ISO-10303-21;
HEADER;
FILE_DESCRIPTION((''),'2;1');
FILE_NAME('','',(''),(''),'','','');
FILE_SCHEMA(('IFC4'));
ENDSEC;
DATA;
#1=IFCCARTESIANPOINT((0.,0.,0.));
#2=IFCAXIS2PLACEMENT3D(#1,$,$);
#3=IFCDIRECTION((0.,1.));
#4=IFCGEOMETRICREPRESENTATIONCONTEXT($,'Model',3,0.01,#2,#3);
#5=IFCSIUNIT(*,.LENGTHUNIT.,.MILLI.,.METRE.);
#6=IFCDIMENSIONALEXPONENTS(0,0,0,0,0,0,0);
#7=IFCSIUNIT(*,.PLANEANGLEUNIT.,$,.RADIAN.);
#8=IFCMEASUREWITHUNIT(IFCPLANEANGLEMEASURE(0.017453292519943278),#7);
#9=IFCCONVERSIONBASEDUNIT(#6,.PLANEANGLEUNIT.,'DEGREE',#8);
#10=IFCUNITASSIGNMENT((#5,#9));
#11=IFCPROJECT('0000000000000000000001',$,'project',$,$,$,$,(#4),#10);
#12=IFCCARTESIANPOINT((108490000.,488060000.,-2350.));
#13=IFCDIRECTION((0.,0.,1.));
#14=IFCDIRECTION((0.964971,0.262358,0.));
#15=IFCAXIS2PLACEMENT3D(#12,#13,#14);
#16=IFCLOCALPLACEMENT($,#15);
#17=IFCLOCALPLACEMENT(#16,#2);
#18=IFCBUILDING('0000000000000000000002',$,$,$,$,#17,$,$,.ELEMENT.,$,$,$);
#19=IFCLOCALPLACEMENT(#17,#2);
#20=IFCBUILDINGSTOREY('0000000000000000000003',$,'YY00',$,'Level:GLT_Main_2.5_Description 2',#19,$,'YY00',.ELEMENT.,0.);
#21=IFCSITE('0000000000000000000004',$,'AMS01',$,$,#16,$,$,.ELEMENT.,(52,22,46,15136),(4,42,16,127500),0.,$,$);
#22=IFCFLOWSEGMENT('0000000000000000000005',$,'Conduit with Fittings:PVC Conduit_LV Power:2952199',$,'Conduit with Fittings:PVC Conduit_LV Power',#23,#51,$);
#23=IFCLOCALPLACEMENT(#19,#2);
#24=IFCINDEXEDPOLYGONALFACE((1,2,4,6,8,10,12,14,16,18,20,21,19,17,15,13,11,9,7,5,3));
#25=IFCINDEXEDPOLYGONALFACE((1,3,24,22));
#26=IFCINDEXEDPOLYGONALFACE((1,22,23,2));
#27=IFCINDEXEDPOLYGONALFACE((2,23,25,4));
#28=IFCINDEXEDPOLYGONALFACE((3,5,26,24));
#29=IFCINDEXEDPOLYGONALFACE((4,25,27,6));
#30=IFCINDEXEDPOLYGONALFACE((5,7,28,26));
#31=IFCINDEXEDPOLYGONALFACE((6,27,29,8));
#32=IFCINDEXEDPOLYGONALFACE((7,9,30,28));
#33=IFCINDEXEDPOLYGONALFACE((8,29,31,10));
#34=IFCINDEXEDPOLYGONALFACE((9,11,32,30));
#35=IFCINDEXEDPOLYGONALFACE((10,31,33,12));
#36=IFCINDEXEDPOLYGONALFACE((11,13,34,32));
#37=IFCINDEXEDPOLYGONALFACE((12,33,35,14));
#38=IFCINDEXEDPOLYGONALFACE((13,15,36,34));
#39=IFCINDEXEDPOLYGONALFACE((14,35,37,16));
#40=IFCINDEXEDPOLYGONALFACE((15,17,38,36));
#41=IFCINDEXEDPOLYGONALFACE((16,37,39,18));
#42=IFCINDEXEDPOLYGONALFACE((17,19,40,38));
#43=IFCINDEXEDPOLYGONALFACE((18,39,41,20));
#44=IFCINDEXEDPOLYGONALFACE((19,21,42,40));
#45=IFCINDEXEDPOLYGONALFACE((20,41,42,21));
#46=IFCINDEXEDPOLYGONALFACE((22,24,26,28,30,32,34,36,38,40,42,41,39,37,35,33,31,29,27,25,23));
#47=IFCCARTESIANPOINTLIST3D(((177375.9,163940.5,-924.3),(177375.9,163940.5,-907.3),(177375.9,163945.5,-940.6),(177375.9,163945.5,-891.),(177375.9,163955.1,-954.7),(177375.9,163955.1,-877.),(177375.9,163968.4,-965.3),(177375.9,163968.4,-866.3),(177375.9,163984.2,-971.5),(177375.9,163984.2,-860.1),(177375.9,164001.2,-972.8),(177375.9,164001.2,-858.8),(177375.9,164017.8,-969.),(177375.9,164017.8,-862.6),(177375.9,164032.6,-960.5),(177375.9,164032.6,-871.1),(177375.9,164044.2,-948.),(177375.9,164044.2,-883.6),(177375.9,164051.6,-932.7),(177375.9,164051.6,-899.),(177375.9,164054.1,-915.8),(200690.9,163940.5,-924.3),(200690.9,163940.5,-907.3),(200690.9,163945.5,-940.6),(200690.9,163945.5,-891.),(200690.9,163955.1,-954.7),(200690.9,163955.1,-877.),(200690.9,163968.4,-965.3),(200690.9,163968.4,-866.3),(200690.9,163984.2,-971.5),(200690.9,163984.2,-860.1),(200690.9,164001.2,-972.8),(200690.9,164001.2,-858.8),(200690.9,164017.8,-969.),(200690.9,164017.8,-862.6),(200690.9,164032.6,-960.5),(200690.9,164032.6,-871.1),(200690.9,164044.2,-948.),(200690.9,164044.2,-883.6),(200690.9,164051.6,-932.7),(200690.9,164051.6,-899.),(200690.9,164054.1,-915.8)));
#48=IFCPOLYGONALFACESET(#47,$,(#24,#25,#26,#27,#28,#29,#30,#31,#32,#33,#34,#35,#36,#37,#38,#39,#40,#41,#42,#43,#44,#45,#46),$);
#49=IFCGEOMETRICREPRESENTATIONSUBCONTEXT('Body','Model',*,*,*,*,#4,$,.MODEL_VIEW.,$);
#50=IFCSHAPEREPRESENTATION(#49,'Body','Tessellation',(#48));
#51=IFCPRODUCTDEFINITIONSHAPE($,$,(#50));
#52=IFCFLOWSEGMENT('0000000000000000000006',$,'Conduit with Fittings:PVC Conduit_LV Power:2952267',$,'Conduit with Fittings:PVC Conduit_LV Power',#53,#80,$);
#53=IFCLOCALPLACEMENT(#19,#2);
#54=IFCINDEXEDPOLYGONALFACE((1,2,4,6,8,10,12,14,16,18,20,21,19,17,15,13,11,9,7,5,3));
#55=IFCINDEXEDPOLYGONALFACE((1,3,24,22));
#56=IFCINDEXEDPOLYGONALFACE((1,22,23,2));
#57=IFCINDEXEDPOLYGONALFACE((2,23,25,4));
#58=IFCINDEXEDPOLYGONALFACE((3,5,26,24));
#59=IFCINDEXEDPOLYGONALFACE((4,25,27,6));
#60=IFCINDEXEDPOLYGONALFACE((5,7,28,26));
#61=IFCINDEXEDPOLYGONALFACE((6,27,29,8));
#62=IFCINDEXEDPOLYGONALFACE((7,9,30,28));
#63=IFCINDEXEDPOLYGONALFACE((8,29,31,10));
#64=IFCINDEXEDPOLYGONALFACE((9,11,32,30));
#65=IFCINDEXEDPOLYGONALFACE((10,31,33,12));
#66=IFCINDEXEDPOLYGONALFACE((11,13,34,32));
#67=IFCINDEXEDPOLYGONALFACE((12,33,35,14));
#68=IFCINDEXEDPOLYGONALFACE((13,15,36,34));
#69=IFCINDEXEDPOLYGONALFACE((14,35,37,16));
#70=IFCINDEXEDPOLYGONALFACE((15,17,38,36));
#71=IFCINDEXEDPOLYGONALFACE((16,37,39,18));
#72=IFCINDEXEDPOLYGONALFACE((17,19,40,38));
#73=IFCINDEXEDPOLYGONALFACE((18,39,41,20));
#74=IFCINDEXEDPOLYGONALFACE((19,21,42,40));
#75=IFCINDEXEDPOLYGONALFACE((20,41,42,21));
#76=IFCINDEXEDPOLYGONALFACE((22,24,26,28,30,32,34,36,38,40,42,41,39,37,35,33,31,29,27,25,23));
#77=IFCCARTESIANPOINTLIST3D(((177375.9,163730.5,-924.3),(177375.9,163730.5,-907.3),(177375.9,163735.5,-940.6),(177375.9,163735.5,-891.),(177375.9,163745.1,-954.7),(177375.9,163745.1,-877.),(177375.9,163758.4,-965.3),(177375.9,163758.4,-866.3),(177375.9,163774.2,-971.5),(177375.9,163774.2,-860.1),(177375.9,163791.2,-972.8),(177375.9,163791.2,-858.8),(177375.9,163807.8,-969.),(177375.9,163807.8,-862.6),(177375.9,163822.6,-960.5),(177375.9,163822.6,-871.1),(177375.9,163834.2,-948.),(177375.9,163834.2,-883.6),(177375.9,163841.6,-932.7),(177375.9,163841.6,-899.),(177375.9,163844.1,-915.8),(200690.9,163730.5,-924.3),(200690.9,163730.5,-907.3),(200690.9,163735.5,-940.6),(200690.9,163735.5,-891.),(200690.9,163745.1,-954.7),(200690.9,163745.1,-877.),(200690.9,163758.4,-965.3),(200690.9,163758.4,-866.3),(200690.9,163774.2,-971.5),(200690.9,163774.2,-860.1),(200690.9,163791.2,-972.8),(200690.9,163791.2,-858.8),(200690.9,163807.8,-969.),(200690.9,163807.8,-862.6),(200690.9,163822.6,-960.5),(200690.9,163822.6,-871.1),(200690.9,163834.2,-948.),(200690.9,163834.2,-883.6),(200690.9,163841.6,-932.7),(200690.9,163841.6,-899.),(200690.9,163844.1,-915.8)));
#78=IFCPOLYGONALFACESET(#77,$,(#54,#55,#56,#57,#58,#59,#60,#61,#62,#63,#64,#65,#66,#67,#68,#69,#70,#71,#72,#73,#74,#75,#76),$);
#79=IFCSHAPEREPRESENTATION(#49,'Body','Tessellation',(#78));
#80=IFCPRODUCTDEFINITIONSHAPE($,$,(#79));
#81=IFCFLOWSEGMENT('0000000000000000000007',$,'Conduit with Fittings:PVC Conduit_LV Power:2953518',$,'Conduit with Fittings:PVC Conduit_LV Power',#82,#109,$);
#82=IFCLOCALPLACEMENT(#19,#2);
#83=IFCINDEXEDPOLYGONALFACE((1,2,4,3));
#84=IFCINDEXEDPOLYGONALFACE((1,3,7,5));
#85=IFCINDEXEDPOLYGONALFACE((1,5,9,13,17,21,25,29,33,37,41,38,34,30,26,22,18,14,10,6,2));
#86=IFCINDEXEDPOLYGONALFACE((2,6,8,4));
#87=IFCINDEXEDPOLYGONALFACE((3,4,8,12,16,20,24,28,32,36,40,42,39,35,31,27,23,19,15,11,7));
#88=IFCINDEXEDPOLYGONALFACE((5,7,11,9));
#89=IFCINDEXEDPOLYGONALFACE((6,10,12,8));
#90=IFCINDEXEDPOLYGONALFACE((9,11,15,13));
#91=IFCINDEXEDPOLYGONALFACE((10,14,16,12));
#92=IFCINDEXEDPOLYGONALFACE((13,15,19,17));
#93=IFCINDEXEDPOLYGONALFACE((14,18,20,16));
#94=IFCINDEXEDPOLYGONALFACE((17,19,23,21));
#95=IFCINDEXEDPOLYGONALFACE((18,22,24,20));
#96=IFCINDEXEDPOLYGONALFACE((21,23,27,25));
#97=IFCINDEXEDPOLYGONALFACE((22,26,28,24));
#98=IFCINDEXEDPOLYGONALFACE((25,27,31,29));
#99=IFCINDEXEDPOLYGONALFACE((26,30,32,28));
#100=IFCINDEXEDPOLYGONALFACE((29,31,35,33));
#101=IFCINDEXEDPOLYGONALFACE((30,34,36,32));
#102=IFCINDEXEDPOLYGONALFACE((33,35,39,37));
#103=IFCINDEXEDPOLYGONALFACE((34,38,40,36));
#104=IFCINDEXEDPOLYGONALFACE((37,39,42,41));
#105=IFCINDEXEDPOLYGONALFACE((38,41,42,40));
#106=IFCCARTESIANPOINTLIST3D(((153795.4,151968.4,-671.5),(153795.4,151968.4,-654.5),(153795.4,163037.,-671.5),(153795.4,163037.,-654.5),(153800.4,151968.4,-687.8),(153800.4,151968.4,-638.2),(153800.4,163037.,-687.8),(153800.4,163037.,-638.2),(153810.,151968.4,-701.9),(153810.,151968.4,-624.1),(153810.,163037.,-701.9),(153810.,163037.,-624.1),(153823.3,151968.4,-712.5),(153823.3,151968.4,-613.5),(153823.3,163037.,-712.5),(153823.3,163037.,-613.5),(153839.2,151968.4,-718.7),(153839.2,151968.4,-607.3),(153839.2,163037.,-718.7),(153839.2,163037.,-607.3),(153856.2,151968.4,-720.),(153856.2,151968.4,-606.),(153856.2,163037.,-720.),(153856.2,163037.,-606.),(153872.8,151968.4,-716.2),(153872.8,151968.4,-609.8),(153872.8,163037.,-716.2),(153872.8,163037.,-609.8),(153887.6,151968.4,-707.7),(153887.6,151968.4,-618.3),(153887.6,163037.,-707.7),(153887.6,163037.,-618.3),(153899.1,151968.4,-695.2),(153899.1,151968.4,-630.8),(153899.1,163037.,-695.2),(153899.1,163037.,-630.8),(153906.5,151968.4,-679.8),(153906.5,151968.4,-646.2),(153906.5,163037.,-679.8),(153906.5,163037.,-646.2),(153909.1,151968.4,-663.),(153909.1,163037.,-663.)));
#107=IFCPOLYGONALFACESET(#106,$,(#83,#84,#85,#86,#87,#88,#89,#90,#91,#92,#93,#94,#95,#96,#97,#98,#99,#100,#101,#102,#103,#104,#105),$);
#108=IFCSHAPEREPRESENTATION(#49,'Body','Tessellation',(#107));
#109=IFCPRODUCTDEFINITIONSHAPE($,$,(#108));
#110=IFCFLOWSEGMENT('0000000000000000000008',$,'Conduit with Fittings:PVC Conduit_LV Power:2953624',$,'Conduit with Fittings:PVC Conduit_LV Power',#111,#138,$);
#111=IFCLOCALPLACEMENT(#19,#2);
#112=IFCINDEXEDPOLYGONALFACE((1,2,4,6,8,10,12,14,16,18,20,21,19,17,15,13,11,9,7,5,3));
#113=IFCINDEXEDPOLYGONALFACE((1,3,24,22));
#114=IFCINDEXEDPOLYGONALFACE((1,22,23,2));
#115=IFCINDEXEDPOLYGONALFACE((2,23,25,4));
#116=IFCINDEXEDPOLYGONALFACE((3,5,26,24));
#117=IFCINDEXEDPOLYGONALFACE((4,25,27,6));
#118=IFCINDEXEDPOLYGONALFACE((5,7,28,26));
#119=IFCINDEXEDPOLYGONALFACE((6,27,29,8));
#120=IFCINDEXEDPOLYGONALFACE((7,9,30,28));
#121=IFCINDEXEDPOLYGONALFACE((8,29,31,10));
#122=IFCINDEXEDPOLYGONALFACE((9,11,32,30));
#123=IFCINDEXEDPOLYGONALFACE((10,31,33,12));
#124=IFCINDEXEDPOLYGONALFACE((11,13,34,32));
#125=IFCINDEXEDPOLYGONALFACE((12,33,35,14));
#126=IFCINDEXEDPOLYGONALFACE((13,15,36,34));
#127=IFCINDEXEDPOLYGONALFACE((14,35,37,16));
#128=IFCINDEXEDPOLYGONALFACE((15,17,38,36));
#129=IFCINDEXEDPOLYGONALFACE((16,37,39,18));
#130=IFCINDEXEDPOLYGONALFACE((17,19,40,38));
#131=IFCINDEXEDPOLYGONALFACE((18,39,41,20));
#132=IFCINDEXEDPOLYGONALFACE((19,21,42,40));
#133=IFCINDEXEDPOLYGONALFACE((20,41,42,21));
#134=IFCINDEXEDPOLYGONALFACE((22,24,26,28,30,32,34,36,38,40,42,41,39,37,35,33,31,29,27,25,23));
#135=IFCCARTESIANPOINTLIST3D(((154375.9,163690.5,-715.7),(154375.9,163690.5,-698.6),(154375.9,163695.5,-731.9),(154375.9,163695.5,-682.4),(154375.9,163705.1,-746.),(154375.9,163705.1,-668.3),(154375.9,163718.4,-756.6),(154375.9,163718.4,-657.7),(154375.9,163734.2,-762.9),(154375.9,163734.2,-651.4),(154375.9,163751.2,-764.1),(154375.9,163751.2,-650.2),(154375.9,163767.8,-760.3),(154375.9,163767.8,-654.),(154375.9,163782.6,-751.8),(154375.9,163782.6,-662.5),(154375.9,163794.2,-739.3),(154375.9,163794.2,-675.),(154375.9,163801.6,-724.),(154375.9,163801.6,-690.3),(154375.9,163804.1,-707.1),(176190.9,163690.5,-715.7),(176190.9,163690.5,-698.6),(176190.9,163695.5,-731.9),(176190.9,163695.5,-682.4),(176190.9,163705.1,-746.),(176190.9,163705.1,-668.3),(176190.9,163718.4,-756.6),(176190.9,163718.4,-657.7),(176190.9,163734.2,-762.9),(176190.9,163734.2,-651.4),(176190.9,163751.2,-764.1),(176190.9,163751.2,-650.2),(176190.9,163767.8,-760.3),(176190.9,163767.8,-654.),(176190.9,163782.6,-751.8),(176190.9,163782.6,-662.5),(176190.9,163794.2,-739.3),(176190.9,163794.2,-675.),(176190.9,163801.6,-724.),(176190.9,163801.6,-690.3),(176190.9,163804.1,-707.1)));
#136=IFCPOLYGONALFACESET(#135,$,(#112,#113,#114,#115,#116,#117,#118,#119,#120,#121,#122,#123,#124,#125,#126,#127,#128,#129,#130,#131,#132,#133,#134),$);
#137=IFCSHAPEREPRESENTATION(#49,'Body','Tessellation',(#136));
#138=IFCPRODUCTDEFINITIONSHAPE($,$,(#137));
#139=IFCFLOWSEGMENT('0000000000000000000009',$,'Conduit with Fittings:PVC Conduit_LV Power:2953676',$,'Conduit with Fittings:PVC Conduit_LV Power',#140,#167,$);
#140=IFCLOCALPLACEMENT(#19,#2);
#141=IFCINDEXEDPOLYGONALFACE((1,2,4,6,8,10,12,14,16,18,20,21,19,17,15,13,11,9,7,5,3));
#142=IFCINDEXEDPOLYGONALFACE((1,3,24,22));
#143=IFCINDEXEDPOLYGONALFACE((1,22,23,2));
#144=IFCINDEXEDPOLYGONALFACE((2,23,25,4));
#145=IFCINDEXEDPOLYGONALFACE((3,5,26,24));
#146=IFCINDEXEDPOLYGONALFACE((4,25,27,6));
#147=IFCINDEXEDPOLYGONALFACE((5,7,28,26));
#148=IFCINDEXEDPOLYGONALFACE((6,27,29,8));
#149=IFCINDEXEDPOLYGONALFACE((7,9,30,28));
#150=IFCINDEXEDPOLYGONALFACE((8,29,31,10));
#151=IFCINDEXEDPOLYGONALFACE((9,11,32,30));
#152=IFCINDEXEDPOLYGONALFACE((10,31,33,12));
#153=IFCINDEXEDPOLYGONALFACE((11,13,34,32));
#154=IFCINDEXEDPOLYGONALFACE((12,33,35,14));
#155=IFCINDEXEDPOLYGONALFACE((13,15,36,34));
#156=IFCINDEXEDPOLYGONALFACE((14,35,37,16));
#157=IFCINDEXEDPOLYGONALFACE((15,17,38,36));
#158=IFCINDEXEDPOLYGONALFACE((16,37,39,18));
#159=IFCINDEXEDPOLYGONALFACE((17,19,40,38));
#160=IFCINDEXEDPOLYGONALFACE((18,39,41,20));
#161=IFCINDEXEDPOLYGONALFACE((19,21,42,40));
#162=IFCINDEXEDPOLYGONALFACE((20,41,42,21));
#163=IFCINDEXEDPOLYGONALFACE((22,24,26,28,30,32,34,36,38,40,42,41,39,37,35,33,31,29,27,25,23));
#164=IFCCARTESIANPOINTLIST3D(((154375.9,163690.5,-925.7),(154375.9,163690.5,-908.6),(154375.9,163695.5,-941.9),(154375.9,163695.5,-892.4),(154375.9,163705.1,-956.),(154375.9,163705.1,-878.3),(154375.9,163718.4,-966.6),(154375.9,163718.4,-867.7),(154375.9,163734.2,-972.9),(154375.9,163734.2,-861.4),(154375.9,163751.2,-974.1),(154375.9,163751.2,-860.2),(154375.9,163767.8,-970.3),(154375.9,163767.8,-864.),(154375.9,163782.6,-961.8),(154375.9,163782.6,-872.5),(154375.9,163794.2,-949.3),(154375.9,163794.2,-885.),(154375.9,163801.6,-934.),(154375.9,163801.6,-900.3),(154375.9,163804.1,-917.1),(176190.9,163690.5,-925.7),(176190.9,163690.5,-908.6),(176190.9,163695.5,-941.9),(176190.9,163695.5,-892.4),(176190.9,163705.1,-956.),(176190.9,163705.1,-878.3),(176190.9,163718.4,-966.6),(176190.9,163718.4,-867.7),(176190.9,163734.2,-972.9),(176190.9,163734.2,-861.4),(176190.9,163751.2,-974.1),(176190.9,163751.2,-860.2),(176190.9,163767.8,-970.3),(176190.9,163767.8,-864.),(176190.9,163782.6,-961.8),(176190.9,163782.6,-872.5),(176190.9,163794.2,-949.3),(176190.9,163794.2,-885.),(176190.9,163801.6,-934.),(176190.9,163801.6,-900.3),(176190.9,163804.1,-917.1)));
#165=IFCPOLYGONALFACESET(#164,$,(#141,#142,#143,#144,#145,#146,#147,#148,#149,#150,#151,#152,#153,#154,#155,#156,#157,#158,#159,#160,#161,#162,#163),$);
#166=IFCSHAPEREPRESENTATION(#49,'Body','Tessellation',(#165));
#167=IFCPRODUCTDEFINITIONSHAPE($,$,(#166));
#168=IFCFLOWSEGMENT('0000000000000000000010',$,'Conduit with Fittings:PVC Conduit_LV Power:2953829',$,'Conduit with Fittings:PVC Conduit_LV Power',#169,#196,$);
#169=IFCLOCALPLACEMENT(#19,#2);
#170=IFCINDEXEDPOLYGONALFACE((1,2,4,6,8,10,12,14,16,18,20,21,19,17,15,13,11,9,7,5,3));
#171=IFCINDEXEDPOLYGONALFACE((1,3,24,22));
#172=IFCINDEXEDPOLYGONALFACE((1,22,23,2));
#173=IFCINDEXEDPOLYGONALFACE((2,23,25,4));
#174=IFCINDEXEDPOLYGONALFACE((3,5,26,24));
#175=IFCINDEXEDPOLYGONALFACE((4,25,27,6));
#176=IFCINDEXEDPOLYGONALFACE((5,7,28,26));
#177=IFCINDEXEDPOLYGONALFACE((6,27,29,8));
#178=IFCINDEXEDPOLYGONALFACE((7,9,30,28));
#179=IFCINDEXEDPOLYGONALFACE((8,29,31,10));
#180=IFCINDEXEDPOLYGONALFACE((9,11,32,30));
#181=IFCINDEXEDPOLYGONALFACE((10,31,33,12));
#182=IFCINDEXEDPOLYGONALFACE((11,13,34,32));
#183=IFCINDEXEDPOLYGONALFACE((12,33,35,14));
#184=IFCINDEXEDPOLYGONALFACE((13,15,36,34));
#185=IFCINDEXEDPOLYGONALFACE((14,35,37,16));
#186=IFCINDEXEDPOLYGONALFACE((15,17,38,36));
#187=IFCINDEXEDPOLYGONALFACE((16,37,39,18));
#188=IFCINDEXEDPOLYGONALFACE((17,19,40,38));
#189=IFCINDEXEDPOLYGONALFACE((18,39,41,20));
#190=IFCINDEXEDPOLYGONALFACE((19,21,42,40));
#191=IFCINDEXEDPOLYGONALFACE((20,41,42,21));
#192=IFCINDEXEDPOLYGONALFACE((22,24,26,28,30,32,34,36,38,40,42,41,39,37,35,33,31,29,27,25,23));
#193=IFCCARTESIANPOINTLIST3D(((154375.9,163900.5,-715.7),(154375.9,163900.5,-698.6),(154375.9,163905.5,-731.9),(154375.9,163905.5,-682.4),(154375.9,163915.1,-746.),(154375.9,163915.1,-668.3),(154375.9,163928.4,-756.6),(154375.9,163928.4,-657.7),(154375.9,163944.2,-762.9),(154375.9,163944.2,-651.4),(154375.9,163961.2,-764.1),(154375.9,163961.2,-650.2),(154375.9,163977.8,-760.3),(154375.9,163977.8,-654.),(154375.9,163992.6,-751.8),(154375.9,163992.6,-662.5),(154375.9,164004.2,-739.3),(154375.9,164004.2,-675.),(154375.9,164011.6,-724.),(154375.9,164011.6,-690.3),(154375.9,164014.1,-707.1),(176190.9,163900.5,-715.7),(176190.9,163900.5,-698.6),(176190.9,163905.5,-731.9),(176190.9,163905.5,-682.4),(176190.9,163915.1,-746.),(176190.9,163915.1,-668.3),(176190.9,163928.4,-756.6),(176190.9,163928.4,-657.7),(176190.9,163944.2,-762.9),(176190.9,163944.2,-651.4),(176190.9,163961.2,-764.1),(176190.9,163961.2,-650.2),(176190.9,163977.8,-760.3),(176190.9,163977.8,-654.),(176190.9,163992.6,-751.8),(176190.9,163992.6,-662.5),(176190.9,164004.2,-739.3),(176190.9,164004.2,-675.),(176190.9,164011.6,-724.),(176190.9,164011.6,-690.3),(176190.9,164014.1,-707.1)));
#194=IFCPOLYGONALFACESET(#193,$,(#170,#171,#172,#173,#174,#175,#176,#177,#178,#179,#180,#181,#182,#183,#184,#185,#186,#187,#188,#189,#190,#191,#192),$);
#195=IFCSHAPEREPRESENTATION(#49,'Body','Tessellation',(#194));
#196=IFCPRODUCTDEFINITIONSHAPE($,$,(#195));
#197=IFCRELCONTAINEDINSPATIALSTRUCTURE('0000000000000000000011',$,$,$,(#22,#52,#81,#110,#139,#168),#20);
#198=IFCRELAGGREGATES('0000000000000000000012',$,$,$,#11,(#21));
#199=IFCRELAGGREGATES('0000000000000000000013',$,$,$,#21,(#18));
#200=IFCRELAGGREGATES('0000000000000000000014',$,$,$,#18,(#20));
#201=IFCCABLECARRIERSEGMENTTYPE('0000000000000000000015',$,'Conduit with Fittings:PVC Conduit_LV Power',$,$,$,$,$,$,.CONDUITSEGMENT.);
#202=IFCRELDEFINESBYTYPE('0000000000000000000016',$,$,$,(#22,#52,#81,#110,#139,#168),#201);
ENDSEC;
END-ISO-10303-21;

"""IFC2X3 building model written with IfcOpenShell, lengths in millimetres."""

from ifc_helpers import new_model, entity, si_unit, converted_unit, direction, frame, frame_2d, origin, origin_2d_with_axis, place, context, subcontext, project, spatial, circle, extrude, type_object, element, save


model = new_model("IFC2X3")

# Units and contexts
model_context = context("Model", 3, precision=0.01, world=origin(), true_north=direction((0.0, 1.0)))
body_context = subcontext(model_context, "Body", "Model", "MODEL_VIEW")
ifc_project = project(units=[si_unit("LENGTHUNIT", "METRE", prefix="MILLI"), converted_unit("PLANEANGLEUNIT", "DEGREE", entity("IfcPlaneAngleMeasure", 0.017453292519943278), si_unit("PLANEANGLEUNIT", "RADIAN"), dimensions=[0, 0, 0, 0, 0, 0, 0])], contexts=[model_context])

# Site, building, storey
site_placement = place(None, frame((108490000.0, 488060000.0, -2350.0), z_axis=(0.0, 0.0, 1.0), x_axis=(0.964971, 0.262358, 0.0)))
site = spatial("IfcSite", under=ifc_project, at=site_placement, Name="AMS01", CompositionType="ELEMENT", RefLatitude=(52, 22, 46, 15136), RefLongitude=(4, 42, 16, 127500), RefElevation=0.0)
building_placement = place(site_placement, origin())
building = spatial("IfcBuilding", under=site, at=building_placement, CompositionType="ELEMENT")
storey_placement = place(building_placement, origin())
storey = spatial("IfcBuildingStorey", under=building, at=storey_placement, Name="YY00", ObjectType="Level:GLT_Main_2.5_Description 2", LongName="YY00", CompositionType="ELEMENT", Elevation=0.0)

# Flow segments
cable_carrier_segment_type = type_object("IfcCableCarrierSegmentType", Name="Conduit with Fittings:PVC Conduit_LV Power", PredefinedType="CONDUITSEGMENT")
flow_segment_1_placement = place(storey_placement, origin())
element("IfcFlowSegment", 1, at=flow_segment_1_placement, inside=storey, type_object=cable_carrier_segment_type, Name="Conduit with Fittings:PVC Conduit_LV Power:2952199", ObjectType="Conduit with Fittings:PVC Conduit_LV Power", context=body_context, shape_type="SweptSolid", body=[
    extrude(circle(Radius=57.2, at=frame_2d((0.0, 0.0), x_axis=(1.0, 0.0))), frame((177375.9, 163997.0, -915.8), z_axis=(1.0, 0.0, 0.0), x_axis=(0.0, 1.0, 0.0)), (0.0, 0.0, 1.0), 23315.0),
])
flow_segment_2_placement = place(storey_placement, origin())
element("IfcFlowSegment", 2, at=flow_segment_2_placement, inside=storey, type_object=cable_carrier_segment_type, Name="Conduit with Fittings:PVC Conduit_LV Power:2952267", ObjectType="Conduit with Fittings:PVC Conduit_LV Power", context=body_context, shape_type="SweptSolid", body=[
    extrude(circle(Radius=57.2, at=frame_2d((0.0, 0.0), x_axis=(1.0, 0.0))), frame((177375.9, 163787.0, -915.8), z_axis=(1.0, 0.0, 0.0), x_axis=(0.0, 1.0, 0.0)), (0.0, 0.0, 1.0), 23315.0),
])
flow_segment_3_placement = place(storey_placement, origin())
element("IfcFlowSegment", 3, at=flow_segment_3_placement, inside=storey, type_object=cable_carrier_segment_type, Name="Conduit with Fittings:PVC Conduit_LV Power:2953518", ObjectType="Conduit with Fittings:PVC Conduit_LV Power", context=body_context, shape_type="SweptSolid", body=[
    extrude(circle(Radius=57.2, at=origin_2d_with_axis()), frame((153851.9, 151968.4, -663.0), z_axis=(0.0, 1.0, 0.0), x_axis=(1.0, 0.0, 0.0)), (0.0, 0.0, 1.0), 11068.6),
])
flow_segment_4_placement = place(storey_placement, origin())
element("IfcFlowSegment", 4, at=flow_segment_4_placement, inside=storey, type_object=cable_carrier_segment_type, Name="Conduit with Fittings:PVC Conduit_LV Power:2953624", ObjectType="Conduit with Fittings:PVC Conduit_LV Power", context=body_context, shape_type="SweptSolid", body=[
    extrude(circle(Radius=57.2, at=frame_2d((0.0, 0.0), x_axis=(1.0, 0.0))), frame((154375.9, 163747.0, -707.1), z_axis=(1.0, 0.0, 0.0), x_axis=(0.0, 1.0, 0.0)), (0.0, 0.0, 1.0), 21815.0),
])
flow_segment_5_placement = place(storey_placement, origin())
element("IfcFlowSegment", 5, at=flow_segment_5_placement, inside=storey, type_object=cable_carrier_segment_type, Name="Conduit with Fittings:PVC Conduit_LV Power:2953676", ObjectType="Conduit with Fittings:PVC Conduit_LV Power", context=body_context, shape_type="SweptSolid", body=[
    extrude(circle(Radius=57.2, at=frame_2d((0.0, 0.0), x_axis=(1.0, 0.0))), frame((154375.9, 163747.0, -917.1), z_axis=(1.0, 0.0, 0.0), x_axis=(0.0, 1.0, 0.0)), (0.0, 0.0, 1.0), 21815.0),
])
flow_segment_6_placement = place(storey_placement, origin())
element("IfcFlowSegment", 6, at=flow_segment_6_placement, inside=storey, type_object=cable_carrier_segment_type, Name="Conduit with Fittings:PVC Conduit_LV Power:2953829", ObjectType="Conduit with Fittings:PVC Conduit_LV Power", context=body_context, shape_type="SweptSolid", body=[
    extrude(circle(Radius=57.2, at=frame_2d((0.0, 0.0), x_axis=(1.0, 0.0))), frame((154375.9, 163957.0, -707.1), z_axis=(1.0, 0.0, 0.0), x_axis=(0.0, 1.0, 0.0)), (0.0, 0.0, 1.0), 21815.0),
])

save(model, "model.ifc")
